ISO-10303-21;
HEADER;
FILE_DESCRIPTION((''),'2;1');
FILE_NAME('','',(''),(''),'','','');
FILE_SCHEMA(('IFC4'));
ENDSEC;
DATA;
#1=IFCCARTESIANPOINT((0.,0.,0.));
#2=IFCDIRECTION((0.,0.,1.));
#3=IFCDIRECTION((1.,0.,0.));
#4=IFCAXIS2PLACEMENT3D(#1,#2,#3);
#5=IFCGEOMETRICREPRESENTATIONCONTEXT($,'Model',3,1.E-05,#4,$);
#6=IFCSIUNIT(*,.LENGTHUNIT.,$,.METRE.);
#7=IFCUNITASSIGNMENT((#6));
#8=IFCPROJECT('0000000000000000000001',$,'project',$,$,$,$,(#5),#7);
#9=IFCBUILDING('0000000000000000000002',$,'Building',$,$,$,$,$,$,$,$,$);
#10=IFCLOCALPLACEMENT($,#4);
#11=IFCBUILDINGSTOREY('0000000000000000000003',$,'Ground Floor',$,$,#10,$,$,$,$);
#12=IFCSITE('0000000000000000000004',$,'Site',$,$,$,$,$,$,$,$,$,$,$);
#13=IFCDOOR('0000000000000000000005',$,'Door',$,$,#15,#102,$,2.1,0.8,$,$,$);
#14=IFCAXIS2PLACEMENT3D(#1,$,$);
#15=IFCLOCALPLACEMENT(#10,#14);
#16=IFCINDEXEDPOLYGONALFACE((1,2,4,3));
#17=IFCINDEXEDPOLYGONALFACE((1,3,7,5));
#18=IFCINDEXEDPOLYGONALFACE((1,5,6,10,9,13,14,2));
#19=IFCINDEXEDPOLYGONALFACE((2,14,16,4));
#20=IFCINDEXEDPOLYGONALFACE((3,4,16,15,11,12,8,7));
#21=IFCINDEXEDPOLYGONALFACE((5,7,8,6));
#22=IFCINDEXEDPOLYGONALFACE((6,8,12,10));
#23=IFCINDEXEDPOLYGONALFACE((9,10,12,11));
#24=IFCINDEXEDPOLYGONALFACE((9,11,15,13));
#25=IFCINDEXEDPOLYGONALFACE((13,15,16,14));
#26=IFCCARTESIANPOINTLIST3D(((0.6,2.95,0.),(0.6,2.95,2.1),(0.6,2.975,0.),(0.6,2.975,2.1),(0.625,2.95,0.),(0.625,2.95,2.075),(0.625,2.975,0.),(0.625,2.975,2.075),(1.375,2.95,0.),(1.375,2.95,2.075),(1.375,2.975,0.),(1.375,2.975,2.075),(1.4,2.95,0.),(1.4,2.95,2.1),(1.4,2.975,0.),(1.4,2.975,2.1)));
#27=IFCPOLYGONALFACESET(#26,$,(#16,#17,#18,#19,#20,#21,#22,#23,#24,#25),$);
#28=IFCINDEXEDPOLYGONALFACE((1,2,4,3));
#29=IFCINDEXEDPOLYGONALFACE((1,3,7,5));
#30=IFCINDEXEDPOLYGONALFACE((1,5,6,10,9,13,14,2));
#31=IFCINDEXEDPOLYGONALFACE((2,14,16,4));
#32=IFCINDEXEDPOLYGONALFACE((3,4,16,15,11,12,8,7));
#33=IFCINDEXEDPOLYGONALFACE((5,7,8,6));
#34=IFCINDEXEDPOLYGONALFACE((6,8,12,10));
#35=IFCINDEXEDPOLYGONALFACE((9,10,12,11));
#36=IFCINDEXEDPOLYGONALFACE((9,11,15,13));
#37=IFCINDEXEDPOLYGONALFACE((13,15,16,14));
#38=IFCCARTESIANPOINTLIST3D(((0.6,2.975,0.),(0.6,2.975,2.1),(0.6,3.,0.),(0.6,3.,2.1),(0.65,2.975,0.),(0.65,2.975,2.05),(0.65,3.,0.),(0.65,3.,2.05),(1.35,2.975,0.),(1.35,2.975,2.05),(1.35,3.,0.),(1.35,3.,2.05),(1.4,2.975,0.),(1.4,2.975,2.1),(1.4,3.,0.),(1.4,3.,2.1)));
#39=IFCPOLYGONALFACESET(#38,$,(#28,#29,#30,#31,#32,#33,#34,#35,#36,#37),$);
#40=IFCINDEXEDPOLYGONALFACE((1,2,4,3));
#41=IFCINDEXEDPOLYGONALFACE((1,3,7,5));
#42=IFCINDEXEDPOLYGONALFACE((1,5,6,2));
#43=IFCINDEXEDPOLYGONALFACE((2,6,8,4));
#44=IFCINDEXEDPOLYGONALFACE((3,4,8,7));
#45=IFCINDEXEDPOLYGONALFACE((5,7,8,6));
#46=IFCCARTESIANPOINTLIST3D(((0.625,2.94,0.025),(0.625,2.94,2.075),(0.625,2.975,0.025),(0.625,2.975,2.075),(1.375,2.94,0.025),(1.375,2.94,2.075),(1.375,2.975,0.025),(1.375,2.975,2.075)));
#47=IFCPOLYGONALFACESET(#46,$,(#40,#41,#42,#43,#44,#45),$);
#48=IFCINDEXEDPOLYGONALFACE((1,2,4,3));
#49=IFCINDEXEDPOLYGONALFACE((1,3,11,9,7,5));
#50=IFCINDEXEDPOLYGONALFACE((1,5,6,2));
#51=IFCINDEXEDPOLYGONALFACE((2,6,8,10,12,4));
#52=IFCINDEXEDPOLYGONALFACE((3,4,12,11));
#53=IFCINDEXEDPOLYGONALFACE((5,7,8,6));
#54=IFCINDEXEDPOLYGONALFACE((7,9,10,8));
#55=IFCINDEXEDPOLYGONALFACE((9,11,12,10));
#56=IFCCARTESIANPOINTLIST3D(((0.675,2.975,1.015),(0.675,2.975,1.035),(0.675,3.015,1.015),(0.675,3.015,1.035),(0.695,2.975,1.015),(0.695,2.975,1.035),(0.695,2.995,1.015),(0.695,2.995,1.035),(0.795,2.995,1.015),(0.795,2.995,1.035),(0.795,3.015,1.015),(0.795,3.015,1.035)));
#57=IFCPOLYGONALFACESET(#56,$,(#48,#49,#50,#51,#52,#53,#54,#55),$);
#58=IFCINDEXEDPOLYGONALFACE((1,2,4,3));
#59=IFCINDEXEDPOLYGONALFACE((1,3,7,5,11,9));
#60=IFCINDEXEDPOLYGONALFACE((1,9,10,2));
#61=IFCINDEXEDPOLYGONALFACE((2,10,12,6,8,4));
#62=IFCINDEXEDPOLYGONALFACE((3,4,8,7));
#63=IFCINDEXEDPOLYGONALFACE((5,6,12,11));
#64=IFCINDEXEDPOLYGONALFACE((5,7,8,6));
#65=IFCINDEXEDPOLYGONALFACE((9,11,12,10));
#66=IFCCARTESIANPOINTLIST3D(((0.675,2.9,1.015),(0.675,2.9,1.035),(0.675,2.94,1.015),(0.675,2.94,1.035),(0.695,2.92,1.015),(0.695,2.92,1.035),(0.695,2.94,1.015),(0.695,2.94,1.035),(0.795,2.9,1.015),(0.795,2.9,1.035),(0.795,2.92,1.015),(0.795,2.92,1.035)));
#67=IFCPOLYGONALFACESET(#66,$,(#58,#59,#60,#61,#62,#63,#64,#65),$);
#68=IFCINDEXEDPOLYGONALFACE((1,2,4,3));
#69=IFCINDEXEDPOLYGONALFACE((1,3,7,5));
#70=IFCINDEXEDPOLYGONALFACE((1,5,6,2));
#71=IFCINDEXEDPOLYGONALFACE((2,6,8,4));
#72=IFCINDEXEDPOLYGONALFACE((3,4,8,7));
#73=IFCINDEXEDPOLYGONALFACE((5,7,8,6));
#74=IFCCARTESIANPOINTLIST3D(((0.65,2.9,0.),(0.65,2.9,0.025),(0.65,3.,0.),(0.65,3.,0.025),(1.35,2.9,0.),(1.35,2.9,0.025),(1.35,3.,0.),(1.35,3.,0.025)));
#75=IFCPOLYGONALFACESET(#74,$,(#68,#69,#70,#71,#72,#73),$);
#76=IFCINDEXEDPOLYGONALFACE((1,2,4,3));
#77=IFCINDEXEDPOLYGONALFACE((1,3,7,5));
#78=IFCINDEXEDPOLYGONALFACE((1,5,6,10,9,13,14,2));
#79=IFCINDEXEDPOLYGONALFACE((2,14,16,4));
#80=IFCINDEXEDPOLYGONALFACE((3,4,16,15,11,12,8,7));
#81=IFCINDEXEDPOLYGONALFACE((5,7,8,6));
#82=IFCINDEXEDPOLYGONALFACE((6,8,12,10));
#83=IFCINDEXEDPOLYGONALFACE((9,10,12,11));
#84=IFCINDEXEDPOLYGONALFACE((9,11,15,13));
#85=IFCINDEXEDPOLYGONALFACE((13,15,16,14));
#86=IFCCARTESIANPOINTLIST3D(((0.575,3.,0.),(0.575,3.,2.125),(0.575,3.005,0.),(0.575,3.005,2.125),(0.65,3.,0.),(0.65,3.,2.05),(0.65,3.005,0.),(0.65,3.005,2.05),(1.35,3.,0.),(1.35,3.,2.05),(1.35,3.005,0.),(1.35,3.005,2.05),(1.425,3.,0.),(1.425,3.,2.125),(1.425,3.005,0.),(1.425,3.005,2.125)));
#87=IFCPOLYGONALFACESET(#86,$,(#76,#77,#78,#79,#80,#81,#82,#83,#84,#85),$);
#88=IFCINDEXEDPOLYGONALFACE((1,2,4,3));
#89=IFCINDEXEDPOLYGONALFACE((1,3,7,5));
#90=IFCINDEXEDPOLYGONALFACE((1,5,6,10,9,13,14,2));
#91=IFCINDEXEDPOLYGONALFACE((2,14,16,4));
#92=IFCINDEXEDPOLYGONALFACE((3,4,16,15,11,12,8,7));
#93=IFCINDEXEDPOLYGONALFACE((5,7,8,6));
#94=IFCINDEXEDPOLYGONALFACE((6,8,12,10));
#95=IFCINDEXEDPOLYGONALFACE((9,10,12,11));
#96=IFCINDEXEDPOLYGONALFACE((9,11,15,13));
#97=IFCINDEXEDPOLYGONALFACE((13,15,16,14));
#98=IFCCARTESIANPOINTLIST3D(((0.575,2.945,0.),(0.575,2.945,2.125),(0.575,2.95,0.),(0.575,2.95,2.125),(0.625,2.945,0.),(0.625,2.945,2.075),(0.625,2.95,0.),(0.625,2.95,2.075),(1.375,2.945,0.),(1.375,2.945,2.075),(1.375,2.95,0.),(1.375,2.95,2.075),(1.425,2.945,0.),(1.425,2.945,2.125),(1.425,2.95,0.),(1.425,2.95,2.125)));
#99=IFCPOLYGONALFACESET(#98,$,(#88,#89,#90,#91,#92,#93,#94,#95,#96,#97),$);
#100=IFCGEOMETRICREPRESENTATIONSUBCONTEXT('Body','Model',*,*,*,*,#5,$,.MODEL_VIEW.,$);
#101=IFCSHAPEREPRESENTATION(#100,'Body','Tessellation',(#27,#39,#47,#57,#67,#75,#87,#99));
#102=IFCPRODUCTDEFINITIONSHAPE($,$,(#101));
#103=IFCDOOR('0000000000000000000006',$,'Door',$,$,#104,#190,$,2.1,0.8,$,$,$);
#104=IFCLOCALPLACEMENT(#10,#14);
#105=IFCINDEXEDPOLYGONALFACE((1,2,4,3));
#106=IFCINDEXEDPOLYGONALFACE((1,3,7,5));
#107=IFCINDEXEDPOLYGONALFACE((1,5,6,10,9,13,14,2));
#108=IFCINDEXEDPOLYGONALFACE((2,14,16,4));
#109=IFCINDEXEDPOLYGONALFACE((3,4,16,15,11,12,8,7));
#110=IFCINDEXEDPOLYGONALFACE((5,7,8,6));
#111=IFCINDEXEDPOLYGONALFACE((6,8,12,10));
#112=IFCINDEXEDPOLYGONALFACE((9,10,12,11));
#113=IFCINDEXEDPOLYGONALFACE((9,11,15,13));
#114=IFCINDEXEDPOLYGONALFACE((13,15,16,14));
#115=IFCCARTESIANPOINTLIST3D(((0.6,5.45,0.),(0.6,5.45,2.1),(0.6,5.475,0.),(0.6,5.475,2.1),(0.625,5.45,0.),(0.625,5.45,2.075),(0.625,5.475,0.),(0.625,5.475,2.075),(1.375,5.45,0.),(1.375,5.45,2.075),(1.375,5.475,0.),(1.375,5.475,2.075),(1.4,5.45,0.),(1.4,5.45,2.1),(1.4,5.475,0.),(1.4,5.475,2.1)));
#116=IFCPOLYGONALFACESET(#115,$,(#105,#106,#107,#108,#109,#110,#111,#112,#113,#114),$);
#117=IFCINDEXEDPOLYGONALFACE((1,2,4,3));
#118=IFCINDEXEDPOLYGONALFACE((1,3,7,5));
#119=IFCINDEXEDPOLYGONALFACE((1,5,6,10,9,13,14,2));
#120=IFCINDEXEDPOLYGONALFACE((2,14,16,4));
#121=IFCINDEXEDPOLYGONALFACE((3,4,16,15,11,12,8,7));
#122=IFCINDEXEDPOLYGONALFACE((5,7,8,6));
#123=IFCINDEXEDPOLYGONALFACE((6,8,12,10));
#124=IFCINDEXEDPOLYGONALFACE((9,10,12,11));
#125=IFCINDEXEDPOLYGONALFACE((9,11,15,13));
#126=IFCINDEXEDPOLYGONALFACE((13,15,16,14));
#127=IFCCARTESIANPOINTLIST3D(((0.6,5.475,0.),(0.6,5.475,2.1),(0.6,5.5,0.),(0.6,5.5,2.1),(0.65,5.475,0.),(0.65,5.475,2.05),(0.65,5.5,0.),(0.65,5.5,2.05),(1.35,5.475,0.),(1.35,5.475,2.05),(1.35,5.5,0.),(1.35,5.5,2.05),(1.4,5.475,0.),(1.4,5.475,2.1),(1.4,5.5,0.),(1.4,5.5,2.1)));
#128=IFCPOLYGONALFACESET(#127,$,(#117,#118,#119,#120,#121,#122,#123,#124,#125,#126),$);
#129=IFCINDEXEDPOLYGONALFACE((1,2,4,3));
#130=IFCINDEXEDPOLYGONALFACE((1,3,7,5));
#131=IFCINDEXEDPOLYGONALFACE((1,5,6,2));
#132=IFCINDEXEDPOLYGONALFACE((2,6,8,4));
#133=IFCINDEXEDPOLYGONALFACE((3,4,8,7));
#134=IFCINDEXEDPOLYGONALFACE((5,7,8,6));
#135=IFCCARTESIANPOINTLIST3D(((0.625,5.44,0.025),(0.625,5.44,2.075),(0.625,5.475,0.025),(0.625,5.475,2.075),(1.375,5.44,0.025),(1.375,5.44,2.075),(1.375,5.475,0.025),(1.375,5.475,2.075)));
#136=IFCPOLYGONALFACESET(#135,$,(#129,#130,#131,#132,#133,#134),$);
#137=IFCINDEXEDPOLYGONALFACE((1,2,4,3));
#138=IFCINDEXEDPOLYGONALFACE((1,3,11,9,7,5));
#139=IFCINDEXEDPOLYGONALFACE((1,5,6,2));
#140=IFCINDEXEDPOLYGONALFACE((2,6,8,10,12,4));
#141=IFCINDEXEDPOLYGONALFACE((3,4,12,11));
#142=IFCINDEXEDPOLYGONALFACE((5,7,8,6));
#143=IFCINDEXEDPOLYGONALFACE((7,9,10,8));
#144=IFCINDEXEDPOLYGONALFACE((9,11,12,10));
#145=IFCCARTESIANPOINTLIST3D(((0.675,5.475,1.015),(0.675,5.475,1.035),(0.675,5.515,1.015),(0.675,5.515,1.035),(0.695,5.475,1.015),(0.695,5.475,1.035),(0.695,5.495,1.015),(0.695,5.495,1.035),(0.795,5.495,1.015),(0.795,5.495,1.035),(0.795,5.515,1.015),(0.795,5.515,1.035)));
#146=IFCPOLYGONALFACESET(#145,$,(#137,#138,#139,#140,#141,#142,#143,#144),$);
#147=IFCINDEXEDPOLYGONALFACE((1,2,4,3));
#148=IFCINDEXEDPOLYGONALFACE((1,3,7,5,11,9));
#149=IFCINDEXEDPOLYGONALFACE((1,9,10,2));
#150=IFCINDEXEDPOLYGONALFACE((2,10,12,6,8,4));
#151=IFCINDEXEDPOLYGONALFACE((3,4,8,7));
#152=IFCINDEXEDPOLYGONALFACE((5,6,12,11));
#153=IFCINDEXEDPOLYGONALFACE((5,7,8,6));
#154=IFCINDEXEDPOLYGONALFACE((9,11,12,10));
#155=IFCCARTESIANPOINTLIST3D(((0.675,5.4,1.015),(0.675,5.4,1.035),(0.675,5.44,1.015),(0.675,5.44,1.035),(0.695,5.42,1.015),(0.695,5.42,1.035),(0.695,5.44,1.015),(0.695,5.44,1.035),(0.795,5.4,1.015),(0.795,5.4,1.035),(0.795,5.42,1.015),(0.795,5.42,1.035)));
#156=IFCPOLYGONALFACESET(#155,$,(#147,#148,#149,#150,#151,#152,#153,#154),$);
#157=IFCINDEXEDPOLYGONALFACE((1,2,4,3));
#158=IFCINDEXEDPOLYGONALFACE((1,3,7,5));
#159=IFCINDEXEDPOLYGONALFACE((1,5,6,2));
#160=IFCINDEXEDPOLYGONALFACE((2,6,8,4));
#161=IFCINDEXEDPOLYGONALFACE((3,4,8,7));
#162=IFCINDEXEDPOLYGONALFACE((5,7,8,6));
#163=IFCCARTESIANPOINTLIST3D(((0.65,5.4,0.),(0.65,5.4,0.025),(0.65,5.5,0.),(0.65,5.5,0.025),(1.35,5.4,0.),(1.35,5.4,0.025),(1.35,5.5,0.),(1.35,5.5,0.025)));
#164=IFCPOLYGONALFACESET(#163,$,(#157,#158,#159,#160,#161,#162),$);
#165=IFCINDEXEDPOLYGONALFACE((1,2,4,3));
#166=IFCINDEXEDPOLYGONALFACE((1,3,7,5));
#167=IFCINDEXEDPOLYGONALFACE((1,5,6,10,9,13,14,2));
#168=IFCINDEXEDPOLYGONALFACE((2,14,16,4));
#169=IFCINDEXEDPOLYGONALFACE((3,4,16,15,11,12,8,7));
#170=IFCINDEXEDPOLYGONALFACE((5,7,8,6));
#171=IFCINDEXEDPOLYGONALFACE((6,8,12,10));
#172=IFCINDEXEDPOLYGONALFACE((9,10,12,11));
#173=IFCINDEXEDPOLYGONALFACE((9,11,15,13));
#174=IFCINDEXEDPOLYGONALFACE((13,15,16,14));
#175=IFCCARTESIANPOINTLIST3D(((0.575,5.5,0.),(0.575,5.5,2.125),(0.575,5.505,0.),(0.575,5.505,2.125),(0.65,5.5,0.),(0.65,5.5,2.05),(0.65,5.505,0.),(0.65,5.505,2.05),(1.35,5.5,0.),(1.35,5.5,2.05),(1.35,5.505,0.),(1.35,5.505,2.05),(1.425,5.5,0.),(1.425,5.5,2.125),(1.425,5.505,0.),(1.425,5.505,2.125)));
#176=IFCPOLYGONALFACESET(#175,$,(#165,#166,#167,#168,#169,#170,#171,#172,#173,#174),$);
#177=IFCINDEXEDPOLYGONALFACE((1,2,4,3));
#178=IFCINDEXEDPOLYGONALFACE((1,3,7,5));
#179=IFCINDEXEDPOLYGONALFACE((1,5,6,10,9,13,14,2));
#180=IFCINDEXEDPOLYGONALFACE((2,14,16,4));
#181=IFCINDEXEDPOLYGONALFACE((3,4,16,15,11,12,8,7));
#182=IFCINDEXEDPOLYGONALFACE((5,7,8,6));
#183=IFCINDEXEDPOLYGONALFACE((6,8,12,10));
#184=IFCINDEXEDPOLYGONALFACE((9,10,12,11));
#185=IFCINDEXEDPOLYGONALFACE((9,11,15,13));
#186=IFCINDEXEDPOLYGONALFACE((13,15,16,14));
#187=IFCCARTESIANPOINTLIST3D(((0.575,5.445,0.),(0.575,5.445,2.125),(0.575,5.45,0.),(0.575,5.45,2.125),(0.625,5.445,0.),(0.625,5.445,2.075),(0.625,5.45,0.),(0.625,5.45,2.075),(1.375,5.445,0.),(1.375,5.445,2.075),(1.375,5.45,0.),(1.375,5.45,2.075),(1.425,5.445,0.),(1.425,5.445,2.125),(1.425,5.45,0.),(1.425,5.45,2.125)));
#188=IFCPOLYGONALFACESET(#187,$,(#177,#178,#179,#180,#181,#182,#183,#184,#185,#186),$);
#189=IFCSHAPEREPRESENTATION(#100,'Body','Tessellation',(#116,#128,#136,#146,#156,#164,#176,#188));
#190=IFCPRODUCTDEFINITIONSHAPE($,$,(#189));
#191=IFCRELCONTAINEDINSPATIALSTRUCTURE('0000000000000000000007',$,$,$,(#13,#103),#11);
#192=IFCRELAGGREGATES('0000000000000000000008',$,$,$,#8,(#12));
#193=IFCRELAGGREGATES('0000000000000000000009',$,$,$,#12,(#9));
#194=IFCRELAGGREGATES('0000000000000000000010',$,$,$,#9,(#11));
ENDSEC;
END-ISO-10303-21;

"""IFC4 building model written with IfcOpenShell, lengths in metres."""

from ifc_helpers import new_model, si_unit, frame, origin_with_axes, place, context, subcontext, project, spatial, line, indexed_curve, outline, extrude, element, save


model = new_model("IFC4")

# Units and contexts
model_context = context("Model", 3, precision=1e-05, world=origin_with_axes())
body_context = subcontext(model_context, "Body", "Model", "MODEL_VIEW")
ifc_project = project(units=[si_unit("LENGTHUNIT", "METRE")], contexts=[model_context])

# Site, building, storey
site = spatial("IfcSite", under=ifc_project, Name="Site")
building = spatial("IfcBuilding", under=site, Name="Building")
storey_placement = place(None, origin_with_axes())
storey = spatial("IfcBuildingStorey", under=building, at=storey_placement, Name="Ground Floor")

# Doors
door_1_placement = place(storey_placement, frame((1.4, 3.0, 0.0), z_axis=(0.0, 0.0, 1.0), x_axis=(-1.0, 0.0, 0.0)))
element("IfcDoor", 1, at=door_1_placement, inside=storey, Name="Door", OverallHeight=2.1, OverallWidth=0.8, context=body_context, shape_type="SweptSolid", body=[
    extrude(outline(indexed_curve([(0.0, 0.0), (0.0, 2.1), (0.8, 2.1), (0.8, 0.0), (0.775, 0.0), (0.775, 2.075), (0.025, 2.075), (0.025, 0.0)], segments=[line(1, 2, 3, 4, 5, 6, 7, 8, 1)])), frame((0.0, 0.025, 0.0), z_axis=(0.0, -1.0, 0.0), x_axis=(1.0, 0.0, 0.0)), (0.0, 0.0, -1.0), 0.025),
    extrude(outline(indexed_curve([(0.0, 0.0), (0.0, 2.1), (0.8, 2.1), (0.8, 0.0), (0.75, 0.0), (0.75, 2.05), (0.05, 2.05), (0.05, 0.0)], segments=[line(1, 2, 3, 4, 5, 6, 7, 8, 1)])), frame((0.0, 0.0, 0.0), z_axis=(0.0, -1.0, 0.0), x_axis=(1.0, 0.0, 0.0)), (0.0, 0.0, -1.0), 0.025),
    extrude(outline(indexed_curve([(0.0, 0.0), (0.75, 0.0), (0.75, 0.035), (0.0, 0.035)], segments=[line(1, 2, 3, 4, 1)])), frame((0.025, 0.025, 0.025), z_axis=(0.0, 0.0, 1.0), x_axis=(1.0, 0.0, 0.0)), (0.0, 0.0, 1.0), 2.05),
    extrude(outline(indexed_curve([(0.0, 0.0), (0.0, -0.04), (-0.12, -0.04), (-0.12, -0.02), (-0.02, -0.02), (-0.02, 0.0)], segments=[line(1, 2, 3, 4, 5, 6, 1)])), frame((0.725, 0.025, 1.015), z_axis=(0.0, 0.0, 1.0), x_axis=(1.0, 0.0, 0.0)), (0.0, 0.0, 1.0), 0.02),
    extrude(outline(indexed_curve([(0.0, 0.0), (0.0, 0.04), (-0.12, 0.04), (-0.12, 0.02), (-0.02, 0.02), (-0.02, 0.0)], segments=[line(1, 2, 3, 4, 5, 6, 1)])), frame((0.725, 0.06, 1.015), z_axis=(0.0, 0.0, 1.0), x_axis=(1.0, 0.0, 0.0)), (0.0, 0.0, 1.0), 0.02),
    extrude(outline(indexed_curve([(0.0, 0.0), (0.7, 0.0), (0.7, 0.1), (0.0, 0.1)], segments=[line(1, 2, 3, 4, 1)])), frame((0.05, 0.0, 0.0), z_axis=(0.0, 0.0, 1.0), x_axis=(1.0, 0.0, 0.0)), (0.0, 0.0, 1.0), 0.025),
    extrude(outline(indexed_curve([(0.0, 0.0), (0.0, 2.125), (0.85, 2.125), (0.85, 0.0), (0.775, 0.0), (0.775, 2.05), (0.075, 2.05), (0.075, 0.0)], segments=[line(1, 2, 3, 4, 5, 6, 7, 8, 1)])), frame((-0.025, -0.005, 0.0), z_axis=(0.0, -1.0, 0.0), x_axis=(1.0, 0.0, 0.0)), (0.0, 0.0, -1.0), 0.005),
    extrude(outline(indexed_curve([(0.0, 0.0), (0.0, 2.125), (0.85, 2.125), (0.85, 0.0), (0.8, 0.0), (0.8, 2.075), (0.05, 2.075), (0.05, 0.0)], segments=[line(1, 2, 3, 4, 5, 6, 7, 8, 1)])), frame((-0.025, 0.05, 0.0), z_axis=(0.0, -1.0, 0.0), x_axis=(1.0, 0.0, 0.0)), (0.0, 0.0, -1.0), 0.005),
])
door_2_placement = place(storey_placement, frame((1.4, 5.5, 0.0), z_axis=(0.0, 0.0, 1.0), x_axis=(-1.0, 0.0, 0.0)))
element("IfcDoor", 2, at=door_2_placement, inside=storey, Name="Door", OverallHeight=2.1, OverallWidth=0.8, context=body_context, shape_type="SweptSolid", body=[
    extrude(outline(indexed_curve([(0.0, 0.0), (0.0, 2.1), (0.8, 2.1), (0.8, 0.0), (0.775, 0.0), (0.775, 2.075), (0.025, 2.075), (0.025, 0.0)], segments=[line(1, 2, 3, 4, 5, 6, 7, 8, 1)])), frame((0.0, 0.025, 0.0), z_axis=(0.0, -1.0, 0.0), x_axis=(1.0, 0.0, 0.0)), (0.0, 0.0, -1.0), 0.025),
    extrude(outline(indexed_curve([(0.0, 0.0), (0.0, 2.1), (0.8, 2.1), (0.8, 0.0), (0.75, 0.0), (0.75, 2.05), (0.05, 2.05), (0.05, 0.0)], segments=[line(1, 2, 3, 4, 5, 6, 7, 8, 1)])), frame((0.0, 0.0, 0.0), z_axis=(0.0, -1.0, 0.0), x_axis=(1.0, 0.0, 0.0)), (0.0, 0.0, -1.0), 0.025),
    extrude(outline(indexed_curve([(0.0, 0.0), (0.75, 0.0), (0.75, 0.035), (0.0, 0.035)], segments=[line(1, 2, 3, 4, 1)])), frame((0.025, 0.025, 0.025), z_axis=(0.0, 0.0, 1.0), x_axis=(1.0, 0.0, 0.0)), (0.0, 0.0, 1.0), 2.05),
    extrude(outline(indexed_curve([(0.0, 0.0), (0.0, -0.04), (-0.12, -0.04), (-0.12, -0.02), (-0.02, -0.02), (-0.02, 0.0)], segments=[line(1, 2, 3, 4, 5, 6, 1)])), frame((0.725, 0.025, 1.015), z_axis=(0.0, 0.0, 1.0), x_axis=(1.0, 0.0, 0.0)), (0.0, 0.0, 1.0), 0.02),
    extrude(outline(indexed_curve([(0.0, 0.0), (0.0, 0.04), (-0.12, 0.04), (-0.12, 0.02), (-0.02, 0.02), (-0.02, 0.0)], segments=[line(1, 2, 3, 4, 5, 6, 1)])), frame((0.725, 0.06, 1.015), z_axis=(0.0, 0.0, 1.0), x_axis=(1.0, 0.0, 0.0)), (0.0, 0.0, 1.0), 0.02),
    extrude(outline(indexed_curve([(0.0, 0.0), (0.7, 0.0), (0.7, 0.1), (0.0, 0.1)], segments=[line(1, 2, 3, 4, 1)])), frame((0.05, 0.0, 0.0), z_axis=(0.0, 0.0, 1.0), x_axis=(1.0, 0.0, 0.0)), (0.0, 0.0, 1.0), 0.025),
    extrude(outline(indexed_curve([(0.0, 0.0), (0.0, 2.125), (0.85, 2.125), (0.85, 0.0), (0.775, 0.0), (0.775, 2.05), (0.075, 2.05), (0.075, 0.0)], segments=[line(1, 2, 3, 4, 5, 6, 7, 8, 1)])), frame((-0.025, -0.005, 0.0), z_axis=(0.0, -1.0, 0.0), x_axis=(1.0, 0.0, 0.0)), (0.0, 0.0, -1.0), 0.005),
    extrude(outline(indexed_curve([(0.0, 0.0), (0.0, 2.125), (0.85, 2.125), (0.85, 0.0), (0.8, 0.0), (0.8, 2.075), (0.05, 2.075), (0.05, 0.0)], segments=[line(1, 2, 3, 4, 5, 6, 7, 8, 1)])), frame((-0.025, 0.05, 0.0), z_axis=(0.0, -1.0, 0.0), x_axis=(1.0, 0.0, 0.0)), (0.0, 0.0, -1.0), 0.005),
])

save(model, "model.ifc")
